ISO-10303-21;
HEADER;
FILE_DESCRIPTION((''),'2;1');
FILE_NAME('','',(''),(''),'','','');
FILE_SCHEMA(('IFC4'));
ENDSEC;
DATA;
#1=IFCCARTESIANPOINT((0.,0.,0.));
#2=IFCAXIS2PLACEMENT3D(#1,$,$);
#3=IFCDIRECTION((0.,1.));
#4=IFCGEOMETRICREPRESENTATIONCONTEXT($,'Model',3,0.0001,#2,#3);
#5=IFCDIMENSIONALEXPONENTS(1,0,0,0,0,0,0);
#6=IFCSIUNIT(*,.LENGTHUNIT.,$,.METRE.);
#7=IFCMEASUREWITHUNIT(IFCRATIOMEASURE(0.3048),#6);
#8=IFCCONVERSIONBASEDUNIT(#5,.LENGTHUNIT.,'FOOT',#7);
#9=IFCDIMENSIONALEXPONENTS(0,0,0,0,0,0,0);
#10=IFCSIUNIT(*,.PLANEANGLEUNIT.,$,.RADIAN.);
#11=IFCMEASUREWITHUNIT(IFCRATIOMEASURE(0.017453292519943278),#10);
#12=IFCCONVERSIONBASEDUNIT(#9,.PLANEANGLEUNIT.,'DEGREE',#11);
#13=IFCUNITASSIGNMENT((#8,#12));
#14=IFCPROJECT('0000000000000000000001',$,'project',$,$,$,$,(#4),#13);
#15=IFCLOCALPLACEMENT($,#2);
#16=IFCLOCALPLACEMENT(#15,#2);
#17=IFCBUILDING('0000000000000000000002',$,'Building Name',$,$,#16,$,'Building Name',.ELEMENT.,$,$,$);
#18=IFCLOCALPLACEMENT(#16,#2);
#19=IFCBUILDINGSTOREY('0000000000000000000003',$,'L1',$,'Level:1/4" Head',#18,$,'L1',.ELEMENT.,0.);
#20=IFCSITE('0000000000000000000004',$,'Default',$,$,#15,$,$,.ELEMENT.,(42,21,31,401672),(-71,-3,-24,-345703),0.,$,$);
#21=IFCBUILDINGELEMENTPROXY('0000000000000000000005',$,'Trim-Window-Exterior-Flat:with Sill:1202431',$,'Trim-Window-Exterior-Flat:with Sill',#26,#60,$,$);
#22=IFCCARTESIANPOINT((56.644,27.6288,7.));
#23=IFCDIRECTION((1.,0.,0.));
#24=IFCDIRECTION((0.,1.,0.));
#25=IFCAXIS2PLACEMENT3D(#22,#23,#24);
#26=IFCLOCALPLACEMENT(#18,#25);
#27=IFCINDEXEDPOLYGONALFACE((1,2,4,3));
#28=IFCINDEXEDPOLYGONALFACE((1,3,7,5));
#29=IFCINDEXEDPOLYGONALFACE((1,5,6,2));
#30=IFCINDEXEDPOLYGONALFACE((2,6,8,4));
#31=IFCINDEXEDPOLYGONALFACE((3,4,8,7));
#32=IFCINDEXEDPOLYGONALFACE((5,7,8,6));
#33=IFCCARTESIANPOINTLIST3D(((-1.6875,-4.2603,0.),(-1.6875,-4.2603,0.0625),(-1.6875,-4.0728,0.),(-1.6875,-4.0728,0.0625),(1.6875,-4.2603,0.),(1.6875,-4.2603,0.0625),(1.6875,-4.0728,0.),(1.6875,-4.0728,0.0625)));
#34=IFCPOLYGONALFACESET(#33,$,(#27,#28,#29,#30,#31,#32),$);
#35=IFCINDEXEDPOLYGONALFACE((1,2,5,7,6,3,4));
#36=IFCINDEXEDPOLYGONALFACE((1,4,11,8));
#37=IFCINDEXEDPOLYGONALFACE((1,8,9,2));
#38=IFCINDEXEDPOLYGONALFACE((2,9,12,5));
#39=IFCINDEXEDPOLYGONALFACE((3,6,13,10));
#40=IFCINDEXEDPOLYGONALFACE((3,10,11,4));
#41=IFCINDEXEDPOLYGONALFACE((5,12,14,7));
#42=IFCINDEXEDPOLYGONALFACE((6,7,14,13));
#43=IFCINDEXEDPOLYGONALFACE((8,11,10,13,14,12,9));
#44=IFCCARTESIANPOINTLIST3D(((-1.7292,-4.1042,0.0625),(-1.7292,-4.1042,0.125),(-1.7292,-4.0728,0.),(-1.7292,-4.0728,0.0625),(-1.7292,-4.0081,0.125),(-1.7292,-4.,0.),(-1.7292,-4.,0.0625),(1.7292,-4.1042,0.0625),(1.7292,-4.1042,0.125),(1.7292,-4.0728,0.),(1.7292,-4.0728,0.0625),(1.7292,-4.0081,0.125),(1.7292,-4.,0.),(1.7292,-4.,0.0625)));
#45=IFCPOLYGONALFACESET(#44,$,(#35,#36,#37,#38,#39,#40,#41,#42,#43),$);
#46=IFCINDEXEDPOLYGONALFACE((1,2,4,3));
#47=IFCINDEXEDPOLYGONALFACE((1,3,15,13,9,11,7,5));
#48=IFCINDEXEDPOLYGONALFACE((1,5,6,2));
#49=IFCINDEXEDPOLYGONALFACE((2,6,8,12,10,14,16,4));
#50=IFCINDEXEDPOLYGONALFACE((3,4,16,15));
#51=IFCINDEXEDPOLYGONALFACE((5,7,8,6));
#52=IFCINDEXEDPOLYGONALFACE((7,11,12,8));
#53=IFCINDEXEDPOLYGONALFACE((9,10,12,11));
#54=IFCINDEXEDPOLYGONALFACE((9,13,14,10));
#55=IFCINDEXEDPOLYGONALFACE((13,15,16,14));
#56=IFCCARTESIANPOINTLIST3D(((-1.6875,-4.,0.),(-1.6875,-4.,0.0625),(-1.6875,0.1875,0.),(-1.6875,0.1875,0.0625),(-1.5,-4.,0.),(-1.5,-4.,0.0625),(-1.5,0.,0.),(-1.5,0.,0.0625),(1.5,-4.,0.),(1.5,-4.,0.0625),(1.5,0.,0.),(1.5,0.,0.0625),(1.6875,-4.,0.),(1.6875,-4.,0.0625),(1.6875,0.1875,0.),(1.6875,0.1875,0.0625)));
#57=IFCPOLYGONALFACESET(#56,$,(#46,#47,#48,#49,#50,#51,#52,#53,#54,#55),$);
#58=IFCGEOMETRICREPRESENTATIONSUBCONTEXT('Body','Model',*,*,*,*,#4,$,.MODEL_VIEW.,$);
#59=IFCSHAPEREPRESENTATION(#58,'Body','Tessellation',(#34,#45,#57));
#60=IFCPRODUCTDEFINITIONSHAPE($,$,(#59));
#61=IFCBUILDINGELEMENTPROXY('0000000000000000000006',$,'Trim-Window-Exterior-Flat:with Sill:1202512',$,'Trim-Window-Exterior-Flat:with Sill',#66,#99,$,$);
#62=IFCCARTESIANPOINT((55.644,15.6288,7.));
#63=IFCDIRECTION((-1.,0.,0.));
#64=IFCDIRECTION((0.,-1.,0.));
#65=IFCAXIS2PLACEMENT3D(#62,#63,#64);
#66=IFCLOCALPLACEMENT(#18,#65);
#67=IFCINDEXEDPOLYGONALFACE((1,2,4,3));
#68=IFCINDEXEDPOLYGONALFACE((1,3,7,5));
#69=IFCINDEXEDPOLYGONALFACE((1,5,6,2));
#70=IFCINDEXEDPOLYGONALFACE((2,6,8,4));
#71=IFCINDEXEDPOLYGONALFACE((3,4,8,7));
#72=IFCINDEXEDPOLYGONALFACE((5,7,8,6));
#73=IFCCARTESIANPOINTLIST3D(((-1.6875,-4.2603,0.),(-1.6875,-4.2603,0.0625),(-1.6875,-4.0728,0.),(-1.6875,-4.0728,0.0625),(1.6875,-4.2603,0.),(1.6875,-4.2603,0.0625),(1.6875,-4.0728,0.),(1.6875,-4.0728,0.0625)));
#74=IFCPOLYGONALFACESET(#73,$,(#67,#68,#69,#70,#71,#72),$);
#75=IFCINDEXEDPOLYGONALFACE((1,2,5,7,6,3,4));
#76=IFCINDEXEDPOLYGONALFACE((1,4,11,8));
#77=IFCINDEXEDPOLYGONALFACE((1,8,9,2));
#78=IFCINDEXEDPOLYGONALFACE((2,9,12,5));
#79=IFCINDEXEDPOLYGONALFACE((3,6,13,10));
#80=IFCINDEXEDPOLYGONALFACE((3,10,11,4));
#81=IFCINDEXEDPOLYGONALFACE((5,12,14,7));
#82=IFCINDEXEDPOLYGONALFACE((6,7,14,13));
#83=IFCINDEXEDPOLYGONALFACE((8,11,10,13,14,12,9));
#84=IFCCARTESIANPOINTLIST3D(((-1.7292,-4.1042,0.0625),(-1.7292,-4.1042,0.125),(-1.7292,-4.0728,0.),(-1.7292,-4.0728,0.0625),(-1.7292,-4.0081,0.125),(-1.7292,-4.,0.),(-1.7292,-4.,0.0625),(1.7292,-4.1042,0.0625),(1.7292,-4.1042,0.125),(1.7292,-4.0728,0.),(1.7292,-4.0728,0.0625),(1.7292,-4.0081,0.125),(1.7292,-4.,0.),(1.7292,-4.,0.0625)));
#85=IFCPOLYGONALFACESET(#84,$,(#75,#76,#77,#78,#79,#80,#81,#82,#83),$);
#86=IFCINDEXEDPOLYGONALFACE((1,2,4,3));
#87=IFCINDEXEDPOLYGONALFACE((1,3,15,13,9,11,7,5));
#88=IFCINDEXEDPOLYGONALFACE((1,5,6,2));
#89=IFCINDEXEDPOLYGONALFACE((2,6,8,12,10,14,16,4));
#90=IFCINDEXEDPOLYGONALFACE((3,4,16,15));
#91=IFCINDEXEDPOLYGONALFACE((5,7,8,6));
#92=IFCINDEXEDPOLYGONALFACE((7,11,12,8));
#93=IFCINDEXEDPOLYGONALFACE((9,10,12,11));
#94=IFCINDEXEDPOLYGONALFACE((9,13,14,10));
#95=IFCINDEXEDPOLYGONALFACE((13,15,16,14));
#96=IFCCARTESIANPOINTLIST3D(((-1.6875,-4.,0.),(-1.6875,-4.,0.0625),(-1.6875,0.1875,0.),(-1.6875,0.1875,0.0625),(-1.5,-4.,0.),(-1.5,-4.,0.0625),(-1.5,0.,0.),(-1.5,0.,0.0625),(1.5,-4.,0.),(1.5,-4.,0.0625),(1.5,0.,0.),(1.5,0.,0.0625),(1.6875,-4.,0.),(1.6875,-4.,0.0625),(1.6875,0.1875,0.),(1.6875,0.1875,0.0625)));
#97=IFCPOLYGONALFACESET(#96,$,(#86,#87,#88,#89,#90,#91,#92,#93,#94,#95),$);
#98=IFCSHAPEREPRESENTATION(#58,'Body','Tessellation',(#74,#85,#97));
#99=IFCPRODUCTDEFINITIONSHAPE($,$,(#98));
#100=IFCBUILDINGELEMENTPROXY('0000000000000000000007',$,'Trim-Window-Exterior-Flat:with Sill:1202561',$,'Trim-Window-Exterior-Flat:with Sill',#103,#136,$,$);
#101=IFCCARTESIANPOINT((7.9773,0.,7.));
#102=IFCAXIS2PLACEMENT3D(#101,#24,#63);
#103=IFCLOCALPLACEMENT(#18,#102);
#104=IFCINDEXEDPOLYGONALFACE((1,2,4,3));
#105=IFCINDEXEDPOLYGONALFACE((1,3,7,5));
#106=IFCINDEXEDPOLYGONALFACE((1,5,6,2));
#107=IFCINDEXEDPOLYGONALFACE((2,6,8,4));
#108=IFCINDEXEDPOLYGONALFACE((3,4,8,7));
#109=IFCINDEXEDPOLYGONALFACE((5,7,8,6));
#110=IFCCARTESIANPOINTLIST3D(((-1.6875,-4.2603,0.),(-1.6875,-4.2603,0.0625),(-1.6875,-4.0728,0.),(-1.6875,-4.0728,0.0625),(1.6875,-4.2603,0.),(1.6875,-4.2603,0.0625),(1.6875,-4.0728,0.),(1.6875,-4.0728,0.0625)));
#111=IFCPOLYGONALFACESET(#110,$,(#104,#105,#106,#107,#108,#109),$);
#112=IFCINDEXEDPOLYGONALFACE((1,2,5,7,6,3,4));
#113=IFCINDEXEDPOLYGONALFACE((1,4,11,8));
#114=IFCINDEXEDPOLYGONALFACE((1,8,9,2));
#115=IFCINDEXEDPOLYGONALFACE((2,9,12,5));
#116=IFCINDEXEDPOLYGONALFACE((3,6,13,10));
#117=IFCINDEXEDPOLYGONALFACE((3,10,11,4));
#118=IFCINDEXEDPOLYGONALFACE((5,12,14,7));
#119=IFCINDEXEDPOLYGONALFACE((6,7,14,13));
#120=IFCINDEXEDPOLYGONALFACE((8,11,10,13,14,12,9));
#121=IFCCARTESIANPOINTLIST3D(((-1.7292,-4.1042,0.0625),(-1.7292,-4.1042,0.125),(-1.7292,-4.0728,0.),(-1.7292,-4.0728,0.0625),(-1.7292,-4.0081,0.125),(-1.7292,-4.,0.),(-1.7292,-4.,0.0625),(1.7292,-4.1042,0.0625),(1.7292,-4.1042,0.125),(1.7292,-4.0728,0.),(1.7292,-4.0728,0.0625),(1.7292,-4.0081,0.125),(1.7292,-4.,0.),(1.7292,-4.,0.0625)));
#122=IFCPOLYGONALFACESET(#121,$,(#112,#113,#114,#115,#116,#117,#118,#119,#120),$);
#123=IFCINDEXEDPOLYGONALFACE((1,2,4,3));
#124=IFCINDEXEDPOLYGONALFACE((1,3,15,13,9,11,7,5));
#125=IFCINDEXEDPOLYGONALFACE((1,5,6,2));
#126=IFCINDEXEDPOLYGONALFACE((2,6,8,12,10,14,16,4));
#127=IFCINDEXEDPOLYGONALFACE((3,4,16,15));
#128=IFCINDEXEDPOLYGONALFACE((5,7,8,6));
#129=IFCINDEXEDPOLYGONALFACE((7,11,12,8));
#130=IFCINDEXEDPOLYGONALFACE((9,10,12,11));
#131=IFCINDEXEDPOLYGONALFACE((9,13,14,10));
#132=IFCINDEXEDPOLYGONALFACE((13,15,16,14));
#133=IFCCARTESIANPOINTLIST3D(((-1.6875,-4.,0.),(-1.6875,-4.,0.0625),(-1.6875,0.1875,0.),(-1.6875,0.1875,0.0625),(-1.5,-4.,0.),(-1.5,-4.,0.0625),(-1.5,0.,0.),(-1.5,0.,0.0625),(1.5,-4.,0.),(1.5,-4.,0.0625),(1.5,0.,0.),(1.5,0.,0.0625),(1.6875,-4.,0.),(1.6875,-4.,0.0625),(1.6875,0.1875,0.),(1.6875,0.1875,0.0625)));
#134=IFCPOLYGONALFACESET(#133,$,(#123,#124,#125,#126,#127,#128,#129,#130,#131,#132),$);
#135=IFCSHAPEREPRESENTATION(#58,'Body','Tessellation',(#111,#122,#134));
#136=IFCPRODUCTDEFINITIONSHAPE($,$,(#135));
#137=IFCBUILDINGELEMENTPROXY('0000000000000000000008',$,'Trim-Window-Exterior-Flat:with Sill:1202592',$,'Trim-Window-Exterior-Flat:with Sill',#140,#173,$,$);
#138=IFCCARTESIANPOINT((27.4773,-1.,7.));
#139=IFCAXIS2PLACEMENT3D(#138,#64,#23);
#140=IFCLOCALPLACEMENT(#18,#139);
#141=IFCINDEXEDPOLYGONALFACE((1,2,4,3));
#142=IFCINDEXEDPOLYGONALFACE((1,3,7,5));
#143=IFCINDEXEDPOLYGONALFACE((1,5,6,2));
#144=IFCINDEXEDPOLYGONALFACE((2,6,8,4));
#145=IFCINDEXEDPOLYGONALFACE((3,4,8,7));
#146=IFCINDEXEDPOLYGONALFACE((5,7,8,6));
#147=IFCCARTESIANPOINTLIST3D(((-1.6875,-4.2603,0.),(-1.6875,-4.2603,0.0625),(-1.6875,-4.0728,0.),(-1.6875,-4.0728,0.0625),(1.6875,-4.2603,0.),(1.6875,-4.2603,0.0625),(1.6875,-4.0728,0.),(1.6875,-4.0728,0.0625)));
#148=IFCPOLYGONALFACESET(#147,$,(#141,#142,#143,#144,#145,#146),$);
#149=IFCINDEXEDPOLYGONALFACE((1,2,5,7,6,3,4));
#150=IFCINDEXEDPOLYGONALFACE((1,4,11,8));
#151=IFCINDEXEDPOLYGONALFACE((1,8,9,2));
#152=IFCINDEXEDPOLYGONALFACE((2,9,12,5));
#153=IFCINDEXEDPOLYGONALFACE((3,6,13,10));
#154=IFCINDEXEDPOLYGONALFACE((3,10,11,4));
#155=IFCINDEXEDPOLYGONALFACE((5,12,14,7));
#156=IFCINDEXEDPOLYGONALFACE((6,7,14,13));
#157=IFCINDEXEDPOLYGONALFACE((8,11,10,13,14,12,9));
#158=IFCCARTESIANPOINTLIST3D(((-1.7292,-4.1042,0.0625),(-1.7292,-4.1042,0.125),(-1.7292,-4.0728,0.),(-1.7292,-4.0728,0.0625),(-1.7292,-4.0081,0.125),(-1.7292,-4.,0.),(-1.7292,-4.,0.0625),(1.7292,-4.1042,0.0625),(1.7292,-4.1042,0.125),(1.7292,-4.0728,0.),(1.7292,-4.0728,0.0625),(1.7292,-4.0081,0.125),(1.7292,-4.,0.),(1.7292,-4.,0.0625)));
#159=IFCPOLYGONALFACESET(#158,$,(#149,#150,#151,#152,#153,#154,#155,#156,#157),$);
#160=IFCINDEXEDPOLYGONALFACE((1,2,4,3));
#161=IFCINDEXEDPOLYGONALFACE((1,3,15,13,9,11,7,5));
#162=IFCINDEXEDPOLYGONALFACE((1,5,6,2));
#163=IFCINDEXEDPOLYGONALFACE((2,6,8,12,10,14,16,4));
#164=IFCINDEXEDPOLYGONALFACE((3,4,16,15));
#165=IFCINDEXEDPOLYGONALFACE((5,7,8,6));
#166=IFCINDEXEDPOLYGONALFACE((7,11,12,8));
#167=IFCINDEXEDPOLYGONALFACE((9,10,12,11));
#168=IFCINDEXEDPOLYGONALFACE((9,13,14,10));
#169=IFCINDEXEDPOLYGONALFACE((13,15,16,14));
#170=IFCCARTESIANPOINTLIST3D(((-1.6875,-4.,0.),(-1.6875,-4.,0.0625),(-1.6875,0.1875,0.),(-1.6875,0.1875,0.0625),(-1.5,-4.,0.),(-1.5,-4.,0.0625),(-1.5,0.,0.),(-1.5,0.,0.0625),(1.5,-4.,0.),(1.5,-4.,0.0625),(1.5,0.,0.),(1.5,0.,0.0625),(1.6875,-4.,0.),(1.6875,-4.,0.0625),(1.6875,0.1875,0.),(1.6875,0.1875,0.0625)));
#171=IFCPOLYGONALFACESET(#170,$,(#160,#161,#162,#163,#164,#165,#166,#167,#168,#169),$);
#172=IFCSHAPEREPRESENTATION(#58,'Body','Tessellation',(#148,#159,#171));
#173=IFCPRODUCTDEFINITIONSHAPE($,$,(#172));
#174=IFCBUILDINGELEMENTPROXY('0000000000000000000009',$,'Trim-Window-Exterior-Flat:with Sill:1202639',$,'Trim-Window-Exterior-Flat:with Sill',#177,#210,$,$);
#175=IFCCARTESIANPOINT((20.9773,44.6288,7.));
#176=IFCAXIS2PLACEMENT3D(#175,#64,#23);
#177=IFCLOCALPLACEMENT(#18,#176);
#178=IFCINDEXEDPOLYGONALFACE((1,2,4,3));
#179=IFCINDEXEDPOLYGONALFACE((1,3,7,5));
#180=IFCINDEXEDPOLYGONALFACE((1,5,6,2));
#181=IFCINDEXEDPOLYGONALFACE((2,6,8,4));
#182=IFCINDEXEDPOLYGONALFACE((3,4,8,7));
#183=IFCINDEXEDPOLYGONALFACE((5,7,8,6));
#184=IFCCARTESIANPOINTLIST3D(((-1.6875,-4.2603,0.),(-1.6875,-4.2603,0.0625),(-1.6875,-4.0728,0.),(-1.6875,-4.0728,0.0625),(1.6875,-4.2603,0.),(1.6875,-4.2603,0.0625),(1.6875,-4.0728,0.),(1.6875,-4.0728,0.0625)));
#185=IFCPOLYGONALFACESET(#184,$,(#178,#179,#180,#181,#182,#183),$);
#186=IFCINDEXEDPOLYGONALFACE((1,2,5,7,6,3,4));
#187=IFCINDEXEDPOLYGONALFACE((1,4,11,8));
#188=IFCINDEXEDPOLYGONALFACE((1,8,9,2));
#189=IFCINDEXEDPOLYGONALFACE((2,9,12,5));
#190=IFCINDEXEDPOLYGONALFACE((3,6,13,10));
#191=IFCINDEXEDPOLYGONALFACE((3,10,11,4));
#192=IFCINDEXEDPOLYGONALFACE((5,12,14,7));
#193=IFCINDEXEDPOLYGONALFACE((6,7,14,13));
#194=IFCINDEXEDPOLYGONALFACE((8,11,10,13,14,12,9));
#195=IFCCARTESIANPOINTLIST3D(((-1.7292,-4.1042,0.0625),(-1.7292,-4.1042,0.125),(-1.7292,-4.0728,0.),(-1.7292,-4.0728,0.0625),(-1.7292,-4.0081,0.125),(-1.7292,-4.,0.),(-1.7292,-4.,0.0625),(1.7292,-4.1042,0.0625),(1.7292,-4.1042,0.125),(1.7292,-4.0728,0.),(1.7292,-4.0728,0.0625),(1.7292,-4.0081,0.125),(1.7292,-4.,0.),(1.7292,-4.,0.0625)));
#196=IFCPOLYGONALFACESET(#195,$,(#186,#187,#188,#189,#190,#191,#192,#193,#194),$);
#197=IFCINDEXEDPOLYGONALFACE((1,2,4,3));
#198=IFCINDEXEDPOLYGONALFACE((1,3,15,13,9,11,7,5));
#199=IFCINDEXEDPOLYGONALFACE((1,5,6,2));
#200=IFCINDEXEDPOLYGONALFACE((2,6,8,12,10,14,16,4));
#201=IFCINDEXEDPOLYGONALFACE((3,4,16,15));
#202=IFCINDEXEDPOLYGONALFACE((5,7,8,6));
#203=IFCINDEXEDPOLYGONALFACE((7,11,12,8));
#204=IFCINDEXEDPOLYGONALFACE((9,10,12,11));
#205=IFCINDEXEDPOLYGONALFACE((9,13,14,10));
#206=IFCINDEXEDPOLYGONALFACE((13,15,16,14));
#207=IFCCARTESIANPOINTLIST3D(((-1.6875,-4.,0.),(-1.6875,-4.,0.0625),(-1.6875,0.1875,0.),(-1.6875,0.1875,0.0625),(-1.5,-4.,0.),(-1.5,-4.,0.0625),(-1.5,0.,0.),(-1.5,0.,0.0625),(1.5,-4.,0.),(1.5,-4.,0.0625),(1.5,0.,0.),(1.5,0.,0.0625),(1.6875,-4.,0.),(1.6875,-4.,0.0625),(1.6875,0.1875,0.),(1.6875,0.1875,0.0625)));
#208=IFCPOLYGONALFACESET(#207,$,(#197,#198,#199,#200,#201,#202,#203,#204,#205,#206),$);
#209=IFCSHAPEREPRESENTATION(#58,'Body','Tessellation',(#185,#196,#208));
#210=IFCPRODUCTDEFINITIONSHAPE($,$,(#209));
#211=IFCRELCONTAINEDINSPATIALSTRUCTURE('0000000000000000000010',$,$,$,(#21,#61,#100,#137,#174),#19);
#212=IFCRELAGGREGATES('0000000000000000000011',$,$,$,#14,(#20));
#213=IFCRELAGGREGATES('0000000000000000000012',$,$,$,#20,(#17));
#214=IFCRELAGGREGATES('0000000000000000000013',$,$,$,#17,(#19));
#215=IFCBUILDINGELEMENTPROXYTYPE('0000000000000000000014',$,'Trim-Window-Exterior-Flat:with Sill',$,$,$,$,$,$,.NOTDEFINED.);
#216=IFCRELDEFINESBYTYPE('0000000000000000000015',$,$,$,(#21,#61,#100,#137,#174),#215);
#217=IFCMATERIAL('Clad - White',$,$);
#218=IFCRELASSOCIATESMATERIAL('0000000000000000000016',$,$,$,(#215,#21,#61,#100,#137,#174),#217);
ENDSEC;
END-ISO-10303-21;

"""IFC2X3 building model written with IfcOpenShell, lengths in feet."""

from ifc_helpers import new_model, entity, si_unit, converted_unit, direction, frame, frame_2d, origin, place, context, subcontext, project, spatial, polyline, rectangle, outline, extrude, source, transform, mapped, material, type_object, type_shapes, element, save


model = new_model("IFC2X3")

# Units and contexts
model_context = context("Model", 3, precision=0.0001, world=origin(), true_north=direction((0.0, 1.0)))
body_context = subcontext(model_context, "Body", "Model", "MODEL_VIEW")
ifc_project = project(units=[converted_unit("LENGTHUNIT", "FOOT", entity("IfcRatioMeasure", 0.3048), si_unit("LENGTHUNIT", "METRE"), dimensions=[1, 0, 0, 0, 0, 0, 0]), converted_unit("PLANEANGLEUNIT", "DEGREE", entity("IfcRatioMeasure", 0.017453292519943278), si_unit("PLANEANGLEUNIT", "RADIAN"), dimensions=[0, 0, 0, 0, 0, 0, 0])], contexts=[model_context])

# Site, building, storey
site_placement = place(None, origin())
site = spatial("IfcSite", under=ifc_project, at=site_placement, Name="Default", CompositionType="ELEMENT", RefLatitude=(42, 21, 31, 401672), RefLongitude=(-71, -3, -24, -345703), RefElevation=0.0)
building_placement = place(site_placement, origin())
building = spatial("IfcBuilding", under=site, at=building_placement, Name="Building Name", LongName="Building Name", CompositionType="ELEMENT")
storey_placement = place(building_placement, origin())
storey = spatial("IfcBuildingStorey", under=building, at=storey_placement, Name="L1", ObjectType="Level:1/4\" Head", LongName="L1", CompositionType="ELEMENT", Elevation=0.0)

# Building element proxies
ifc_material_1 = material(Name="Clad - White")
building_element_proxy_type_1 = type_object("IfcBuildingElementProxyType", Name="Trim-Window-Exterior-Flat:with Sill", PredefinedType="NOTDEFINED", material=ifc_material_1)
shared_shape_1 = source(origin(), body_context, "Body", "SweptSolid", [
    extrude(rectangle(XDim=3.375, YDim=0.1875, at=frame_2d((0.0, 0.0), x_axis=(1.0, 0.0))), frame((0.0, -4.1665, 0.0), z_axis=(0.0, 0.0, 1.0), x_axis=(-1.0, 0.0, 0.0)), (0.0, 0.0, 1.0), 0.0625),
    extrude(outline(polyline([(-0.0625, -0.0525), (0.0, -0.0525), (0.0, -0.0211), (0.0625, -0.0211), (0.0625, 0.0517), (0.0, 0.0517), (-0.0625, 0.0436), (-0.0625, -0.0525)])), frame((-1.7292, -4.0517, 0.0625), z_axis=(1.0, 0.0, 0.0), x_axis=(0.0, 0.0, -1.0)), (0.0, 0.0, 1.0), 3.4583),
    extrude(outline(polyline([(-2.1406, -1.6875), (2.0469, -1.6875), (2.0469, -1.5), (-1.9531, -1.5), (-1.9531, 1.5), (2.0469, 1.5), (2.0469, 1.6875), (-2.1406, 1.6875), (-2.1406, -1.6875)])), frame((0.0, -1.9531, 0.0), z_axis=(0.0, 0.0, 1.0), x_axis=(0.0, -1.0, 0.0)), (0.0, 0.0, 1.0), 0.0625),
])
type_shapes(building_element_proxy_type_1, [shared_shape_1])
for number, where, z_axis, x_axis, name in (
    (1, (56.644, 27.6288, 7.0), (1.0, 0.0, 0.0), (0.0, 1.0, 0.0), "Trim-Window-Exterior-Flat:with Sill:1202431"),
    (2, (55.644, 15.6288, 7.0), (-1.0, 0.0, 0.0), (0.0, -1.0, 0.0), "Trim-Window-Exterior-Flat:with Sill:1202512"),
    (3, (7.9773, 0.0, 7.0), (0.0, 1.0, 0.0), (-1.0, 0.0, 0.0), "Trim-Window-Exterior-Flat:with Sill:1202561"),
    (4, (27.4773, -1.0, 7.0), (0.0, -1.0, 0.0), (1.0, 0.0, 0.0), "Trim-Window-Exterior-Flat:with Sill:1202592"),
    (5, (20.9773, 44.6288, 7.0), (0.0, -1.0, 0.0), (1.0, 0.0, 0.0), "Trim-Window-Exterior-Flat:with Sill:1202639"),
):
    element("IfcBuildingElementProxy", number, at=place(storey_placement, frame(where, z_axis=z_axis, x_axis=x_axis)), inside=storey, type_object=building_element_proxy_type_1, material=ifc_material_1, Name=name, ObjectType="Trim-Window-Exterior-Flat:with Sill", context=body_context, shape_type="MappedRepresentation", body=[
        mapped(shared_shape_1, transform((0.0, 0.0, 0.0), scale=1.0)),
    ])

save(model, "model.ifc")
